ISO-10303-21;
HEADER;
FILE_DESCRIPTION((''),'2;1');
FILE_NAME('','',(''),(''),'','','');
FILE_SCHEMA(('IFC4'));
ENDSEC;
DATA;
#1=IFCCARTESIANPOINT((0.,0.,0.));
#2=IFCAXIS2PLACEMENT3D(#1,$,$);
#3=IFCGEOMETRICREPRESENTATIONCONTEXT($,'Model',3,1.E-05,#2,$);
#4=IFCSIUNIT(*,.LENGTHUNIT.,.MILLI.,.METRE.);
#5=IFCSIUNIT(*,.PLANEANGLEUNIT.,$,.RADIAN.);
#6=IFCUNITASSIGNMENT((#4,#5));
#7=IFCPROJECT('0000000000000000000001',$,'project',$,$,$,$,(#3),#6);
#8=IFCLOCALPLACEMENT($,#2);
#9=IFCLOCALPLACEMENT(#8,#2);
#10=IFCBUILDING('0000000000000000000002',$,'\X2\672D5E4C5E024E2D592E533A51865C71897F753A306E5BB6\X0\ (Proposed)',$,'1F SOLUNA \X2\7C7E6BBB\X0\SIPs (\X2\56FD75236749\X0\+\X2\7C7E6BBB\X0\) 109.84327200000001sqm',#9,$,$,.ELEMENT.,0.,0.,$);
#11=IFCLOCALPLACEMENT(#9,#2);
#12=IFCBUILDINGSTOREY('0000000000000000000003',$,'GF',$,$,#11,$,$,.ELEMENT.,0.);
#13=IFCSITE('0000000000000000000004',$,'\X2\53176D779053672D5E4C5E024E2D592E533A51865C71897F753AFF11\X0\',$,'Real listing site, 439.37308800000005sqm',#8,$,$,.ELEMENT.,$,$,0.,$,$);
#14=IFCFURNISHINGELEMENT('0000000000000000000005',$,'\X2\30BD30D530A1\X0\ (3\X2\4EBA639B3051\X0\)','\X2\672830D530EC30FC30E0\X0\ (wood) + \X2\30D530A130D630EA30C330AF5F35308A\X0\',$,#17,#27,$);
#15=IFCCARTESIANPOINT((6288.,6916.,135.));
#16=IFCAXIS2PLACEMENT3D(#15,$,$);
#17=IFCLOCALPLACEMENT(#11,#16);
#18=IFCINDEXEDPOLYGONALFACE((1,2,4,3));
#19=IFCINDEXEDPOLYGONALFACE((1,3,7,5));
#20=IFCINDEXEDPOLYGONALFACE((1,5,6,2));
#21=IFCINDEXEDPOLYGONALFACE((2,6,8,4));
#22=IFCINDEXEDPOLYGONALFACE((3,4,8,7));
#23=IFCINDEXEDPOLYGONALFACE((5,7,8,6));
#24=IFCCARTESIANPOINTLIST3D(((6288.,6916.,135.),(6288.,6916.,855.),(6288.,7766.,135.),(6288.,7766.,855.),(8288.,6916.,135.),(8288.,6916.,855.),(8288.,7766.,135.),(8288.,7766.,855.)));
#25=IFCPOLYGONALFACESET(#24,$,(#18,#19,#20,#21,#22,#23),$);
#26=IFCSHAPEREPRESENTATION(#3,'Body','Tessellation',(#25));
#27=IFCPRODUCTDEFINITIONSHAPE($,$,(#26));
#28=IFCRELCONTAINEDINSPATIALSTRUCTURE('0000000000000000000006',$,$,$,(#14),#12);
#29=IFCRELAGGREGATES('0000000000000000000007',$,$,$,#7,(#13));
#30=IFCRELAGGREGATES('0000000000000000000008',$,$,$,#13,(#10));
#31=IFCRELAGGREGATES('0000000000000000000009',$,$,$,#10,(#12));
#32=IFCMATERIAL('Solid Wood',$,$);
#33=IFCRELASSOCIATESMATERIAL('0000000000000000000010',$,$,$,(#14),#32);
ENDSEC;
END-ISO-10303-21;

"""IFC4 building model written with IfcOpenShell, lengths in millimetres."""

from ifc_helpers import new_model, si_unit, frame, frame_2d, origin, place, context, project, spatial, rectangle, extrude, material, element, save


model = new_model("IFC4")

# Units and contexts
model_context = context("Model", 3, precision=1e-05, world=origin())
ifc_project = project(units=[si_unit("LENGTHUNIT", "METRE", prefix="MILLI"), si_unit("PLANEANGLEUNIT", "RADIAN")], contexts=[model_context])

# Site, building, storey
site_placement = place(None, origin())
site = spatial("IfcSite", under=ifc_project, at=site_placement, Name="北海道札幌市中央区円山西町１", ObjectType="Real listing site, 439.37308800000005sqm", CompositionType="ELEMENT", RefElevation=0.0)
building_placement = place(site_placement, origin())
building = spatial("IfcBuilding", under=site, at=building_placement, Name="札幌市中央区円山西町の家 (Proposed)", ObjectType="1F SOLUNA 籾殻SIPs (国産杉+籾殻) 109.84327200000001sqm", CompositionType="ELEMENT", ElevationOfRefHeight=0.0, ElevationOfTerrain=0.0)
storey_placement = place(building_placement, origin())
storey = spatial("IfcBuildingStorey", under=building, at=storey_placement, Name="GF", CompositionType="ELEMENT", Elevation=0.0)

# Shared definitions
ifc_material_1 = material(Name="Solid Wood")

# Furnishing element
furnishing_1_placement = place(storey_placement, frame((6288.0, 6916.0, 135.0)))
element("IfcFurnishingElement", 1, at=furnishing_1_placement, inside=storey, material=ifc_material_1, Name="ソファ (3人掛け)", Description="木フレーム (wood) + ファブリック張り", context=model_context, shape_type="SweptSolid", body=[
    extrude(rectangle(XDim=2000.0, YDim=850.0, at=frame_2d((1000.0, 425.0))), frame((6288.0, 6916.0, 135.0)), (0.0, 0.0, 1.0), 720.0),
])

save(model, "model.ifc")
